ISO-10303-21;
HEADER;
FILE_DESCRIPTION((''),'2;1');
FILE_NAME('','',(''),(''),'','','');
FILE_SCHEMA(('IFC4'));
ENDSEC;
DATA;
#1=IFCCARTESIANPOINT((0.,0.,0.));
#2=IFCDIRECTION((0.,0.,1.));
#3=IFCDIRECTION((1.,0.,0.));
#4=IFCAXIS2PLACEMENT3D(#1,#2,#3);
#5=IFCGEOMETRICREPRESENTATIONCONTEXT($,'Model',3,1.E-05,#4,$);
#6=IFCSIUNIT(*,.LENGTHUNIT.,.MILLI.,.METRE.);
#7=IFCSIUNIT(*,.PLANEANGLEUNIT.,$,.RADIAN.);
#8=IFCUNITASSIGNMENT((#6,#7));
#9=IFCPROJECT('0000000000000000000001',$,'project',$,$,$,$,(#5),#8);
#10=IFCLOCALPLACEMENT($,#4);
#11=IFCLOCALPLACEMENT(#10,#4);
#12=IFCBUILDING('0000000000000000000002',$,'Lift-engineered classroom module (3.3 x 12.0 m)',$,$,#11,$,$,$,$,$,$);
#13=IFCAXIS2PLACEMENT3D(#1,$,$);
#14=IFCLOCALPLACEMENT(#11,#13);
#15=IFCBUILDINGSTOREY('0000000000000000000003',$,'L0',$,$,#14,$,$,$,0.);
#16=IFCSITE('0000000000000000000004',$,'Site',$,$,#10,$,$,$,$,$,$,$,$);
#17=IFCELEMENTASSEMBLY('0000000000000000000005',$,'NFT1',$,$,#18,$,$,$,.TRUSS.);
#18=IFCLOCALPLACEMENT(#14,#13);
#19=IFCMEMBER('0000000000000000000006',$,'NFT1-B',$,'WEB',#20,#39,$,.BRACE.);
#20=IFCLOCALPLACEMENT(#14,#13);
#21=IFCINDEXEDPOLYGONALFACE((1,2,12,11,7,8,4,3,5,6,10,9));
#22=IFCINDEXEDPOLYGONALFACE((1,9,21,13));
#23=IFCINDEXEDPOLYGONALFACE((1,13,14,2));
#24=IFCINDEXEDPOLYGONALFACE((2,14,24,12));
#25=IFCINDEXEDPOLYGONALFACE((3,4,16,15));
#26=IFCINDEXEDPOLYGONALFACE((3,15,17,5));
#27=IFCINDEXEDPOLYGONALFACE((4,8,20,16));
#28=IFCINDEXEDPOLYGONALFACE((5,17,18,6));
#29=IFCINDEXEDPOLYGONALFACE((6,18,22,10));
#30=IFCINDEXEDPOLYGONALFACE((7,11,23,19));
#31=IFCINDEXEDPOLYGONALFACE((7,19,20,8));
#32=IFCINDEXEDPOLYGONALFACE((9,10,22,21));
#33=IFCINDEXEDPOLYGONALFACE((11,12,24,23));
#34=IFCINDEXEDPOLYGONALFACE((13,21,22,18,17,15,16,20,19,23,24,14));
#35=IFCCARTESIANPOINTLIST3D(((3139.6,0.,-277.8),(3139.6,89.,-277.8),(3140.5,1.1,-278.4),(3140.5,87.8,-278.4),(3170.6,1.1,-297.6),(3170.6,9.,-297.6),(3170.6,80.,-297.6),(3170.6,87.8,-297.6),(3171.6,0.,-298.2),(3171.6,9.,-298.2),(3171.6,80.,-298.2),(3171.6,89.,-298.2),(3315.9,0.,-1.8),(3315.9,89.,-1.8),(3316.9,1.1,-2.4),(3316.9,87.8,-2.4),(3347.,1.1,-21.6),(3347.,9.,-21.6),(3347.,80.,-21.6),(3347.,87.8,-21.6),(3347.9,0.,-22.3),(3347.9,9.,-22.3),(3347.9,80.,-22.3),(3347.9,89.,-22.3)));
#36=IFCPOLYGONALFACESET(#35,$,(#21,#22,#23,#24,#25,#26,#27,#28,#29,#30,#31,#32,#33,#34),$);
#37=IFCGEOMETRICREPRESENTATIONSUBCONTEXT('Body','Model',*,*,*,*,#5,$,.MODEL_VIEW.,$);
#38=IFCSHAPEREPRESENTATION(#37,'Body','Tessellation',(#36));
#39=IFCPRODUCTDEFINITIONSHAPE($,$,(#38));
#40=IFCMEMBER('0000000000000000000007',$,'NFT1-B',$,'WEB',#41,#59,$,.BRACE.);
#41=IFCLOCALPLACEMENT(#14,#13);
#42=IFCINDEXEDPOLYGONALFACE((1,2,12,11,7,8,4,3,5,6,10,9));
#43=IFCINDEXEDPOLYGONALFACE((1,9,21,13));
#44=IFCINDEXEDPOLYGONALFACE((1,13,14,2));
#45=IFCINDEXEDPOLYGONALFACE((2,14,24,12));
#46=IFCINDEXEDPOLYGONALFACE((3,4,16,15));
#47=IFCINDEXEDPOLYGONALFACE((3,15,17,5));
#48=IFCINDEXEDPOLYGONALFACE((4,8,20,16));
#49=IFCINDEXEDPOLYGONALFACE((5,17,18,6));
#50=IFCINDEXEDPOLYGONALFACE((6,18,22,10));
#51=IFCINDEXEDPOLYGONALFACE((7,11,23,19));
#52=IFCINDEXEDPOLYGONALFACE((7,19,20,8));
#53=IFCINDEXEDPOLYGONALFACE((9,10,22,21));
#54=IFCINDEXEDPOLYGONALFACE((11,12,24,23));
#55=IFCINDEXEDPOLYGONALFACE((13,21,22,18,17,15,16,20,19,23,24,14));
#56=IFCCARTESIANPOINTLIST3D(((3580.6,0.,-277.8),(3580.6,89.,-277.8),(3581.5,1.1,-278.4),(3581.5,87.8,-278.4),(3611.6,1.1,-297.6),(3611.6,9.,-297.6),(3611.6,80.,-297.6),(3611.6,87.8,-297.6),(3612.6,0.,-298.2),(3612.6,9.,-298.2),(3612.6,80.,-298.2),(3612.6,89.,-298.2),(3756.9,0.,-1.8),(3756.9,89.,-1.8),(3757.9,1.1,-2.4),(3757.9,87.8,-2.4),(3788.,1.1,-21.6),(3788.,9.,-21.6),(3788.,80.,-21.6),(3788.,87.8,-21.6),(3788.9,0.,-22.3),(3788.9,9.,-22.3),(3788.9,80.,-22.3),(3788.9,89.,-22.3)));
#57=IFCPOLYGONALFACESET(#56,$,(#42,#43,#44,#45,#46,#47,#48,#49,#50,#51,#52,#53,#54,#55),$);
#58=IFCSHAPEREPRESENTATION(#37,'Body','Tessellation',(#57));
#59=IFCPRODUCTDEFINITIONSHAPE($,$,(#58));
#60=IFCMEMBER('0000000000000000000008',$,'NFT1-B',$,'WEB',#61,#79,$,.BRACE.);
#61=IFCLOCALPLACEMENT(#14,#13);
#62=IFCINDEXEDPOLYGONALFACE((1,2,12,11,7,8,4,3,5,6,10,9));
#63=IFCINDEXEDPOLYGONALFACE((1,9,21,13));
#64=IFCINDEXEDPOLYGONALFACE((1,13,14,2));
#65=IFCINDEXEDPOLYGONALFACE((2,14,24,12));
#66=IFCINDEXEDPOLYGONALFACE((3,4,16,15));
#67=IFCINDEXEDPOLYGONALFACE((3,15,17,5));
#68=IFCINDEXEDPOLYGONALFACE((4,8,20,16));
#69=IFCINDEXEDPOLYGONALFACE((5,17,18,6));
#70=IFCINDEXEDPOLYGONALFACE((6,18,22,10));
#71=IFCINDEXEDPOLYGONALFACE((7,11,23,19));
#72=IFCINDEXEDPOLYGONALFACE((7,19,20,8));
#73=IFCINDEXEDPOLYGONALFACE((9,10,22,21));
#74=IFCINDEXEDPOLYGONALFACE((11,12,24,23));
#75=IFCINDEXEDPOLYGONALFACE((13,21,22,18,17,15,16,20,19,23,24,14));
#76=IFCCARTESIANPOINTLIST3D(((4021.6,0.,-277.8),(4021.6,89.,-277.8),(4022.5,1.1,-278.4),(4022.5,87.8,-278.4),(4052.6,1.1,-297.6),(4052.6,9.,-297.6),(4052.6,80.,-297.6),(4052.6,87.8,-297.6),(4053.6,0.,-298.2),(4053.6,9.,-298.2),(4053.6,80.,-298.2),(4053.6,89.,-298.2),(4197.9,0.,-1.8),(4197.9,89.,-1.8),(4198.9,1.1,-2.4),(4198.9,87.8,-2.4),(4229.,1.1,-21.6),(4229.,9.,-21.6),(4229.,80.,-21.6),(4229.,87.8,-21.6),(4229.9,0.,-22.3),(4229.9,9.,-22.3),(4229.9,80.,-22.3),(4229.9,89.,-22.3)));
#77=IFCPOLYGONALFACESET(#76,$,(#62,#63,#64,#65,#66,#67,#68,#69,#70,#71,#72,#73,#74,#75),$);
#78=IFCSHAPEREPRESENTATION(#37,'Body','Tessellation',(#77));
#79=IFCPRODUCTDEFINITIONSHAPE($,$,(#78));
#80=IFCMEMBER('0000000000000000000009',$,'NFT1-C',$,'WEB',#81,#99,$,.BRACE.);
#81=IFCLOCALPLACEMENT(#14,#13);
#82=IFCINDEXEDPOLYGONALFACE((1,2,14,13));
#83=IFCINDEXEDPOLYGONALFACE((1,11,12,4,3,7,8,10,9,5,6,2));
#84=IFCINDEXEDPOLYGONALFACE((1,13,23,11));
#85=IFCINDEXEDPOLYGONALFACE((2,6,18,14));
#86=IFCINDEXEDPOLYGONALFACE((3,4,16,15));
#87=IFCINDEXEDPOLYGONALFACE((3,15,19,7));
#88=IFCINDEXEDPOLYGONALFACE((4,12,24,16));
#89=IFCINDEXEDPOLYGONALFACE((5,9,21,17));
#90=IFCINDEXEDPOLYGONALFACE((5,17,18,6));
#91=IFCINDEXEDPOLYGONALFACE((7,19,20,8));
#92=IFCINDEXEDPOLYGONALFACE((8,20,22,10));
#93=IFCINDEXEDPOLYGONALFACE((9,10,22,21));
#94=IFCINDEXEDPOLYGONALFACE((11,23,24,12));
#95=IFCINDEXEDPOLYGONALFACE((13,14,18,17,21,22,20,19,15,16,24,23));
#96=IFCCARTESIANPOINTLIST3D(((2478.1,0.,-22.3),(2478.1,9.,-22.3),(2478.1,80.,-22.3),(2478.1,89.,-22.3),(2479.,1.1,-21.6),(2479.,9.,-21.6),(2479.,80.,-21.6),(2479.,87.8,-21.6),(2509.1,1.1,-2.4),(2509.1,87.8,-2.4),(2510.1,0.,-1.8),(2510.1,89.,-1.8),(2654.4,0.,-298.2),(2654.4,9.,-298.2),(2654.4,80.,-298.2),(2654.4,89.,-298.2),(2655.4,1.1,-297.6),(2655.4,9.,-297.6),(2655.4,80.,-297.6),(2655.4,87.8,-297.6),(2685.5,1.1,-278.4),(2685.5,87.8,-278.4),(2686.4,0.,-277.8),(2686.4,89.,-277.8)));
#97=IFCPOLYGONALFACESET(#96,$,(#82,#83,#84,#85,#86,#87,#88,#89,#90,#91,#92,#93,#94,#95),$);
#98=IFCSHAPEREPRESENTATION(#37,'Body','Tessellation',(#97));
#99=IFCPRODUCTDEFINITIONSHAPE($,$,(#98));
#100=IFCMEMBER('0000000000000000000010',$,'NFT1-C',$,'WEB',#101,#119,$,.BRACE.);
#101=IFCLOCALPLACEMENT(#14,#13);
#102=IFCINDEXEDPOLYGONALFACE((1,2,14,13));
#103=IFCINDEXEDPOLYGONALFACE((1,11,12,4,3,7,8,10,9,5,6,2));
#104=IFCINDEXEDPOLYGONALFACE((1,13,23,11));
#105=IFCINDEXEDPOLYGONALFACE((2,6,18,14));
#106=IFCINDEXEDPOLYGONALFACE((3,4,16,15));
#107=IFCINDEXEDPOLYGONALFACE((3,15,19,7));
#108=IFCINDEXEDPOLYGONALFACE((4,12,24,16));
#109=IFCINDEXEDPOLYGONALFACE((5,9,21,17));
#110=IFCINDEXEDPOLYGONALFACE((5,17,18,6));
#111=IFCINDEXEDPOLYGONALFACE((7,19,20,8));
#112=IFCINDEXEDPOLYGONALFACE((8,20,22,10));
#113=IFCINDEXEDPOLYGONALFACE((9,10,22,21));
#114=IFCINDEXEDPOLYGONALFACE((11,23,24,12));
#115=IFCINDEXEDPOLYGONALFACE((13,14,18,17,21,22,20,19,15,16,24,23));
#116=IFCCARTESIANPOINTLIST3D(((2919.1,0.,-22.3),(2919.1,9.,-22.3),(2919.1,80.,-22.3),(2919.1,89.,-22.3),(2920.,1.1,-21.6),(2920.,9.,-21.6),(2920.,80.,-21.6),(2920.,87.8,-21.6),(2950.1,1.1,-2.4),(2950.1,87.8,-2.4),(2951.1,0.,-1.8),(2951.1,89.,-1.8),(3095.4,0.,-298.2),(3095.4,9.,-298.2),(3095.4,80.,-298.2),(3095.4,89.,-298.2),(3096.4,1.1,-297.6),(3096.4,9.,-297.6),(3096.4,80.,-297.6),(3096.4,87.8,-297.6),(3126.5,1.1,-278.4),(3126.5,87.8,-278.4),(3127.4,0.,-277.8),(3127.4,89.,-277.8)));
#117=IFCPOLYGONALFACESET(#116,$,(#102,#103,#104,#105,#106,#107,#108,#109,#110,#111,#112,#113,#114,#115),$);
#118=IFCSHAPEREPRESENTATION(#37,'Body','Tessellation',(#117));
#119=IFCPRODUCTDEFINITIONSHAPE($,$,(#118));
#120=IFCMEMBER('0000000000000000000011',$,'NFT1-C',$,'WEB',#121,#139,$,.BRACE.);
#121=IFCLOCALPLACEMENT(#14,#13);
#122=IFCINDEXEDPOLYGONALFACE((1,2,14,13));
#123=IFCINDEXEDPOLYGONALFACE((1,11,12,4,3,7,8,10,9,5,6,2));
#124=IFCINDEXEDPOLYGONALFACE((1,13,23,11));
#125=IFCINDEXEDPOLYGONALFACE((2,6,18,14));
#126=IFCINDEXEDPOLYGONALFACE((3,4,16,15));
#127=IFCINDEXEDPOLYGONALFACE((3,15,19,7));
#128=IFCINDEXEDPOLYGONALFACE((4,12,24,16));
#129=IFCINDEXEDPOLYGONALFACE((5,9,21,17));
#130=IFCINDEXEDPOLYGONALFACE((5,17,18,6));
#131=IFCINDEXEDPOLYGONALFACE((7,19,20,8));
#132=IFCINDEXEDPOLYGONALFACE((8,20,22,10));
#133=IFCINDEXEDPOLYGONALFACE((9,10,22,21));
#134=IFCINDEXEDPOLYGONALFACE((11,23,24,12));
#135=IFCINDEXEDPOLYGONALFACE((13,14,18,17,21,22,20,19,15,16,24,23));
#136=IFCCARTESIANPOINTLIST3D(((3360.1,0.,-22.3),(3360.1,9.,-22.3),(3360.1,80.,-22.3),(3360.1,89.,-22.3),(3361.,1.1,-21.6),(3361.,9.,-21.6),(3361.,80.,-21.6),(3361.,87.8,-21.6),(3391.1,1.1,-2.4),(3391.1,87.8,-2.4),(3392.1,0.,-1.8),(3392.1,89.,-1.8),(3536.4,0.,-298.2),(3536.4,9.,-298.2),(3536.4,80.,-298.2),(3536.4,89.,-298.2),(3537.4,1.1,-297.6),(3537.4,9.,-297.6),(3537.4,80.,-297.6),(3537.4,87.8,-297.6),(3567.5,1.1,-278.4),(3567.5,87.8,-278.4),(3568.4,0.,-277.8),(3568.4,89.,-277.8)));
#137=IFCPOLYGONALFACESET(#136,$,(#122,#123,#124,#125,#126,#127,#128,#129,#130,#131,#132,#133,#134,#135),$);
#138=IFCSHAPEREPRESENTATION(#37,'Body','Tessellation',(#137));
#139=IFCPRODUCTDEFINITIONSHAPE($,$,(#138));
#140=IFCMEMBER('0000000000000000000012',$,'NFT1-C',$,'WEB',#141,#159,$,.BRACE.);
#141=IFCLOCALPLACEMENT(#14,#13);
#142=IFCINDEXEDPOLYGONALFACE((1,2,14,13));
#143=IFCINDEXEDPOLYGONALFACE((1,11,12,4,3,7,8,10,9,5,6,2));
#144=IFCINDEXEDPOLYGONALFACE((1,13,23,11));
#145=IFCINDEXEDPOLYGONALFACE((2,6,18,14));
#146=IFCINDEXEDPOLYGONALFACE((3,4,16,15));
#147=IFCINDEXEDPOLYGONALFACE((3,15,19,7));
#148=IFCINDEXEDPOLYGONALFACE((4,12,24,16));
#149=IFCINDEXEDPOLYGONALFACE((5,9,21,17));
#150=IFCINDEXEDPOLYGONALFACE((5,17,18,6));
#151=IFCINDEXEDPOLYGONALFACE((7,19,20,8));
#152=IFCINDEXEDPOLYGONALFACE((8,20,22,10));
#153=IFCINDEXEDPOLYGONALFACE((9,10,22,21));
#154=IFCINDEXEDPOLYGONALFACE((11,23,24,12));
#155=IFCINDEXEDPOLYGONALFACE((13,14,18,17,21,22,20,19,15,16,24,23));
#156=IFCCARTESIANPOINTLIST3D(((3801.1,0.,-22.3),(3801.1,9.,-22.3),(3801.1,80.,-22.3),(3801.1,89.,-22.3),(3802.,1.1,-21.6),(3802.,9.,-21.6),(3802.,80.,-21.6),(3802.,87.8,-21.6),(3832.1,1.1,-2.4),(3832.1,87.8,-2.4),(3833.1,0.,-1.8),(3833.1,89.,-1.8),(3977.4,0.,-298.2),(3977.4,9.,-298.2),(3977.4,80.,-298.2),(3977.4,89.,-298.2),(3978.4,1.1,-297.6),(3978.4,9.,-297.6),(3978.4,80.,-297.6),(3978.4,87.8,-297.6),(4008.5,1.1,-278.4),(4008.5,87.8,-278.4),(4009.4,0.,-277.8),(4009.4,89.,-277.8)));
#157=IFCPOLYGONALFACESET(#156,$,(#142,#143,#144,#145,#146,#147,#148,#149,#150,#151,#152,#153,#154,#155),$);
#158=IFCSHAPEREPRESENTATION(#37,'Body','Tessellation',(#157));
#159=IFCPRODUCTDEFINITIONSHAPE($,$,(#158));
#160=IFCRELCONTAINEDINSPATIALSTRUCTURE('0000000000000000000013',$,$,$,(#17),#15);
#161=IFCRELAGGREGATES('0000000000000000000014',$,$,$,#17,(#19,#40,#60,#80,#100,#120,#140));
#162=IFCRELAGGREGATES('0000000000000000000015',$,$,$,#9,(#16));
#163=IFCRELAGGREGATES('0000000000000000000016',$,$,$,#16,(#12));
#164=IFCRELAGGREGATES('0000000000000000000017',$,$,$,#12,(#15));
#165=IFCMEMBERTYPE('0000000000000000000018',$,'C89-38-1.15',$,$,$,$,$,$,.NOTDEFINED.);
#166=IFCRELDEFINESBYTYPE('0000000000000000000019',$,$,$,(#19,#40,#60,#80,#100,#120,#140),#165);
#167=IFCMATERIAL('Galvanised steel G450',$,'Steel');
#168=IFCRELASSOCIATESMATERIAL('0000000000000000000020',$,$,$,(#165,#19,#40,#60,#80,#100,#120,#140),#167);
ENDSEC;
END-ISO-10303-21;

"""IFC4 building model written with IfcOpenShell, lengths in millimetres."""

from ifc_helpers import new_model, si_unit, frame, origin, origin_with_axes, origin_2d, place, context, subcontext, project, spatial, c_section, extrude, material, material_profile, profile_set, profile_usage, type_object, element, aggregate, save


model = new_model("IFC4")

# Units and contexts
model_context = context("Model", 3, precision=1e-05, world=origin_with_axes())
body_context = subcontext(model_context, "Body", "Model", "MODEL_VIEW")
ifc_project = project(units=[si_unit("LENGTHUNIT", "METRE", prefix="MILLI"), si_unit("PLANEANGLEUNIT", "RADIAN")], contexts=[model_context])

# Site, building, storey
site_placement = place(None, origin_with_axes())
site = spatial("IfcSite", under=ifc_project, at=site_placement, Name="Site")
building_placement = place(site_placement, origin_with_axes())
building = spatial("IfcBuilding", under=site, at=building_placement, Name="Lift-engineered classroom module (3.3 x 12.0 m)")
storey_placement = place(building_placement, origin())
storey = spatial("IfcBuildingStorey", under=building, at=storey_placement, Name="L0", Elevation=0.0)

# Element assembly, members
ifc_material = material(Name="Galvanised steel G450", Category="Steel")
assembly_1_placement = place(storey_placement, frame((0.0, 44.5, -300.0)))
assembly_1 = element("IfcElementAssembly", 1, at=assembly_1_placement, inside=storey, Name="NFT1", PredefinedType="TRUSS")
ifc_material_profile_1 = material_profile(ifc_material, c_section(Depth=89.0, Width=38.0, WallThickness=1.1, Girth=9.0, at=origin_2d()), Name="C89-38-1.15")
ifc_profile_set_1 = profile_set([ifc_material_profile_1], Name="C89-38-1.15")
ifc_profile_usage_1 = profile_usage(ifc_profile_set_1)
member_type_1 = type_object("IfcMemberType", Name="C89-38-1.15", PredefinedType="NOTDEFINED", material=ifc_profile_set_1)
member_1_placement = place(assembly_1_placement, frame((3155.6, 0.0, 12.0), z_axis=(0.538459, 0.0, 0.842652), x_axis=(0.842652, 0.0, -0.538459)))
member_1 = element("IfcMember", 2, at=member_1_placement, type_object=member_type_1, material=ifc_profile_usage_1, Name="NFT1-B", ObjectType="WEB", PredefinedType="BRACE", context=body_context, shape_type="SweptSolid", body=[
    extrude(c_section(Depth=89.0, Width=38.0, WallThickness=1.1, Girth=9.0, at=origin_2d()), origin(), (0.0, 0.0, 1.0), 327.5),
])
member_2_placement = place(assembly_1_placement, frame((3596.6, 0.0, 12.0), z_axis=(0.538459, 0.0, 0.842652), x_axis=(0.842652, 0.0, -0.538459)))
member_2 = element("IfcMember", 3, at=member_2_placement, type_object=member_type_1, material=ifc_profile_usage_1, Name="NFT1-B", ObjectType="WEB", PredefinedType="BRACE", context=body_context, shape_type="SweptSolid", body=[
    extrude(c_section(Depth=89.0, Width=38.0, WallThickness=1.1, Girth=9.0, at=origin_2d()), origin(), (0.0, 0.0, 1.0), 327.5),
])
member_3_placement = place(assembly_1_placement, frame((4037.6, 0.0, 12.0), z_axis=(0.538459, 0.0, 0.842652), x_axis=(0.842652, 0.0, -0.538459)))
member_3 = element("IfcMember", 4, at=member_3_placement, type_object=member_type_1, material=ifc_profile_usage_1, Name="NFT1-B", ObjectType="WEB", PredefinedType="BRACE", context=body_context, shape_type="SweptSolid", body=[
    extrude(c_section(Depth=89.0, Width=38.0, WallThickness=1.1, Girth=9.0, at=origin_2d()), origin(), (0.0, 0.0, 1.0), 327.5),
])
member_4_placement = place(assembly_1_placement, frame((2670.4, 0.0, 12.0), z_axis=(-0.538459, 0.0, 0.842652), x_axis=(-0.842652, 0.0, -0.538459)))
member_4 = element("IfcMember", 5, at=member_4_placement, type_object=member_type_1, material=ifc_profile_usage_1, Name="NFT1-C", ObjectType="WEB", PredefinedType="BRACE", context=body_context, shape_type="SweptSolid", body=[
    extrude(c_section(Depth=89.0, Width=38.0, WallThickness=1.1, Girth=9.0, at=origin_2d()), origin(), (0.0, 0.0, 1.0), 327.5),
])
member_5_placement = place(assembly_1_placement, frame((3111.4, 0.0, 12.0), z_axis=(-0.538459, 0.0, 0.842652), x_axis=(-0.842652, 0.0, -0.538459)))
member_5 = element("IfcMember", 6, at=member_5_placement, type_object=member_type_1, material=ifc_profile_usage_1, Name="NFT1-C", ObjectType="WEB", PredefinedType="BRACE", context=body_context, shape_type="SweptSolid", body=[
    extrude(c_section(Depth=89.0, Width=38.0, WallThickness=1.1, Girth=9.0, at=origin_2d()), origin(), (0.0, 0.0, 1.0), 327.5),
])
member_6_placement = place(assembly_1_placement, frame((3552.4, 0.0, 12.0), z_axis=(-0.538459, 0.0, 0.842652), x_axis=(-0.842652, 0.0, -0.538459)))
member_6 = element("IfcMember", 7, at=member_6_placement, type_object=member_type_1, material=ifc_profile_usage_1, Name="NFT1-C", ObjectType="WEB", PredefinedType="BRACE", context=body_context, shape_type="SweptSolid", body=[
    extrude(c_section(Depth=89.0, Width=38.0, WallThickness=1.1, Girth=9.0, at=origin_2d()), origin(), (0.0, 0.0, 1.0), 327.5),
])
member_7_placement = place(assembly_1_placement, frame((3993.4, 0.0, 12.0), z_axis=(-0.538459, 0.0, 0.842652), x_axis=(-0.842652, 0.0, -0.538459)))
member_7 = element("IfcMember", 8, at=member_7_placement, type_object=member_type_1, material=ifc_profile_usage_1, Name="NFT1-C", ObjectType="WEB", PredefinedType="BRACE", context=body_context, shape_type="SweptSolid", body=[
    extrude(c_section(Depth=89.0, Width=38.0, WallThickness=1.1, Girth=9.0, at=origin_2d()), origin(), (0.0, 0.0, 1.0), 327.5),
])
aggregate(assembly_1, [member_1, member_2, member_3, member_4, member_5, member_6, member_7])

save(model, "model.ifc")
